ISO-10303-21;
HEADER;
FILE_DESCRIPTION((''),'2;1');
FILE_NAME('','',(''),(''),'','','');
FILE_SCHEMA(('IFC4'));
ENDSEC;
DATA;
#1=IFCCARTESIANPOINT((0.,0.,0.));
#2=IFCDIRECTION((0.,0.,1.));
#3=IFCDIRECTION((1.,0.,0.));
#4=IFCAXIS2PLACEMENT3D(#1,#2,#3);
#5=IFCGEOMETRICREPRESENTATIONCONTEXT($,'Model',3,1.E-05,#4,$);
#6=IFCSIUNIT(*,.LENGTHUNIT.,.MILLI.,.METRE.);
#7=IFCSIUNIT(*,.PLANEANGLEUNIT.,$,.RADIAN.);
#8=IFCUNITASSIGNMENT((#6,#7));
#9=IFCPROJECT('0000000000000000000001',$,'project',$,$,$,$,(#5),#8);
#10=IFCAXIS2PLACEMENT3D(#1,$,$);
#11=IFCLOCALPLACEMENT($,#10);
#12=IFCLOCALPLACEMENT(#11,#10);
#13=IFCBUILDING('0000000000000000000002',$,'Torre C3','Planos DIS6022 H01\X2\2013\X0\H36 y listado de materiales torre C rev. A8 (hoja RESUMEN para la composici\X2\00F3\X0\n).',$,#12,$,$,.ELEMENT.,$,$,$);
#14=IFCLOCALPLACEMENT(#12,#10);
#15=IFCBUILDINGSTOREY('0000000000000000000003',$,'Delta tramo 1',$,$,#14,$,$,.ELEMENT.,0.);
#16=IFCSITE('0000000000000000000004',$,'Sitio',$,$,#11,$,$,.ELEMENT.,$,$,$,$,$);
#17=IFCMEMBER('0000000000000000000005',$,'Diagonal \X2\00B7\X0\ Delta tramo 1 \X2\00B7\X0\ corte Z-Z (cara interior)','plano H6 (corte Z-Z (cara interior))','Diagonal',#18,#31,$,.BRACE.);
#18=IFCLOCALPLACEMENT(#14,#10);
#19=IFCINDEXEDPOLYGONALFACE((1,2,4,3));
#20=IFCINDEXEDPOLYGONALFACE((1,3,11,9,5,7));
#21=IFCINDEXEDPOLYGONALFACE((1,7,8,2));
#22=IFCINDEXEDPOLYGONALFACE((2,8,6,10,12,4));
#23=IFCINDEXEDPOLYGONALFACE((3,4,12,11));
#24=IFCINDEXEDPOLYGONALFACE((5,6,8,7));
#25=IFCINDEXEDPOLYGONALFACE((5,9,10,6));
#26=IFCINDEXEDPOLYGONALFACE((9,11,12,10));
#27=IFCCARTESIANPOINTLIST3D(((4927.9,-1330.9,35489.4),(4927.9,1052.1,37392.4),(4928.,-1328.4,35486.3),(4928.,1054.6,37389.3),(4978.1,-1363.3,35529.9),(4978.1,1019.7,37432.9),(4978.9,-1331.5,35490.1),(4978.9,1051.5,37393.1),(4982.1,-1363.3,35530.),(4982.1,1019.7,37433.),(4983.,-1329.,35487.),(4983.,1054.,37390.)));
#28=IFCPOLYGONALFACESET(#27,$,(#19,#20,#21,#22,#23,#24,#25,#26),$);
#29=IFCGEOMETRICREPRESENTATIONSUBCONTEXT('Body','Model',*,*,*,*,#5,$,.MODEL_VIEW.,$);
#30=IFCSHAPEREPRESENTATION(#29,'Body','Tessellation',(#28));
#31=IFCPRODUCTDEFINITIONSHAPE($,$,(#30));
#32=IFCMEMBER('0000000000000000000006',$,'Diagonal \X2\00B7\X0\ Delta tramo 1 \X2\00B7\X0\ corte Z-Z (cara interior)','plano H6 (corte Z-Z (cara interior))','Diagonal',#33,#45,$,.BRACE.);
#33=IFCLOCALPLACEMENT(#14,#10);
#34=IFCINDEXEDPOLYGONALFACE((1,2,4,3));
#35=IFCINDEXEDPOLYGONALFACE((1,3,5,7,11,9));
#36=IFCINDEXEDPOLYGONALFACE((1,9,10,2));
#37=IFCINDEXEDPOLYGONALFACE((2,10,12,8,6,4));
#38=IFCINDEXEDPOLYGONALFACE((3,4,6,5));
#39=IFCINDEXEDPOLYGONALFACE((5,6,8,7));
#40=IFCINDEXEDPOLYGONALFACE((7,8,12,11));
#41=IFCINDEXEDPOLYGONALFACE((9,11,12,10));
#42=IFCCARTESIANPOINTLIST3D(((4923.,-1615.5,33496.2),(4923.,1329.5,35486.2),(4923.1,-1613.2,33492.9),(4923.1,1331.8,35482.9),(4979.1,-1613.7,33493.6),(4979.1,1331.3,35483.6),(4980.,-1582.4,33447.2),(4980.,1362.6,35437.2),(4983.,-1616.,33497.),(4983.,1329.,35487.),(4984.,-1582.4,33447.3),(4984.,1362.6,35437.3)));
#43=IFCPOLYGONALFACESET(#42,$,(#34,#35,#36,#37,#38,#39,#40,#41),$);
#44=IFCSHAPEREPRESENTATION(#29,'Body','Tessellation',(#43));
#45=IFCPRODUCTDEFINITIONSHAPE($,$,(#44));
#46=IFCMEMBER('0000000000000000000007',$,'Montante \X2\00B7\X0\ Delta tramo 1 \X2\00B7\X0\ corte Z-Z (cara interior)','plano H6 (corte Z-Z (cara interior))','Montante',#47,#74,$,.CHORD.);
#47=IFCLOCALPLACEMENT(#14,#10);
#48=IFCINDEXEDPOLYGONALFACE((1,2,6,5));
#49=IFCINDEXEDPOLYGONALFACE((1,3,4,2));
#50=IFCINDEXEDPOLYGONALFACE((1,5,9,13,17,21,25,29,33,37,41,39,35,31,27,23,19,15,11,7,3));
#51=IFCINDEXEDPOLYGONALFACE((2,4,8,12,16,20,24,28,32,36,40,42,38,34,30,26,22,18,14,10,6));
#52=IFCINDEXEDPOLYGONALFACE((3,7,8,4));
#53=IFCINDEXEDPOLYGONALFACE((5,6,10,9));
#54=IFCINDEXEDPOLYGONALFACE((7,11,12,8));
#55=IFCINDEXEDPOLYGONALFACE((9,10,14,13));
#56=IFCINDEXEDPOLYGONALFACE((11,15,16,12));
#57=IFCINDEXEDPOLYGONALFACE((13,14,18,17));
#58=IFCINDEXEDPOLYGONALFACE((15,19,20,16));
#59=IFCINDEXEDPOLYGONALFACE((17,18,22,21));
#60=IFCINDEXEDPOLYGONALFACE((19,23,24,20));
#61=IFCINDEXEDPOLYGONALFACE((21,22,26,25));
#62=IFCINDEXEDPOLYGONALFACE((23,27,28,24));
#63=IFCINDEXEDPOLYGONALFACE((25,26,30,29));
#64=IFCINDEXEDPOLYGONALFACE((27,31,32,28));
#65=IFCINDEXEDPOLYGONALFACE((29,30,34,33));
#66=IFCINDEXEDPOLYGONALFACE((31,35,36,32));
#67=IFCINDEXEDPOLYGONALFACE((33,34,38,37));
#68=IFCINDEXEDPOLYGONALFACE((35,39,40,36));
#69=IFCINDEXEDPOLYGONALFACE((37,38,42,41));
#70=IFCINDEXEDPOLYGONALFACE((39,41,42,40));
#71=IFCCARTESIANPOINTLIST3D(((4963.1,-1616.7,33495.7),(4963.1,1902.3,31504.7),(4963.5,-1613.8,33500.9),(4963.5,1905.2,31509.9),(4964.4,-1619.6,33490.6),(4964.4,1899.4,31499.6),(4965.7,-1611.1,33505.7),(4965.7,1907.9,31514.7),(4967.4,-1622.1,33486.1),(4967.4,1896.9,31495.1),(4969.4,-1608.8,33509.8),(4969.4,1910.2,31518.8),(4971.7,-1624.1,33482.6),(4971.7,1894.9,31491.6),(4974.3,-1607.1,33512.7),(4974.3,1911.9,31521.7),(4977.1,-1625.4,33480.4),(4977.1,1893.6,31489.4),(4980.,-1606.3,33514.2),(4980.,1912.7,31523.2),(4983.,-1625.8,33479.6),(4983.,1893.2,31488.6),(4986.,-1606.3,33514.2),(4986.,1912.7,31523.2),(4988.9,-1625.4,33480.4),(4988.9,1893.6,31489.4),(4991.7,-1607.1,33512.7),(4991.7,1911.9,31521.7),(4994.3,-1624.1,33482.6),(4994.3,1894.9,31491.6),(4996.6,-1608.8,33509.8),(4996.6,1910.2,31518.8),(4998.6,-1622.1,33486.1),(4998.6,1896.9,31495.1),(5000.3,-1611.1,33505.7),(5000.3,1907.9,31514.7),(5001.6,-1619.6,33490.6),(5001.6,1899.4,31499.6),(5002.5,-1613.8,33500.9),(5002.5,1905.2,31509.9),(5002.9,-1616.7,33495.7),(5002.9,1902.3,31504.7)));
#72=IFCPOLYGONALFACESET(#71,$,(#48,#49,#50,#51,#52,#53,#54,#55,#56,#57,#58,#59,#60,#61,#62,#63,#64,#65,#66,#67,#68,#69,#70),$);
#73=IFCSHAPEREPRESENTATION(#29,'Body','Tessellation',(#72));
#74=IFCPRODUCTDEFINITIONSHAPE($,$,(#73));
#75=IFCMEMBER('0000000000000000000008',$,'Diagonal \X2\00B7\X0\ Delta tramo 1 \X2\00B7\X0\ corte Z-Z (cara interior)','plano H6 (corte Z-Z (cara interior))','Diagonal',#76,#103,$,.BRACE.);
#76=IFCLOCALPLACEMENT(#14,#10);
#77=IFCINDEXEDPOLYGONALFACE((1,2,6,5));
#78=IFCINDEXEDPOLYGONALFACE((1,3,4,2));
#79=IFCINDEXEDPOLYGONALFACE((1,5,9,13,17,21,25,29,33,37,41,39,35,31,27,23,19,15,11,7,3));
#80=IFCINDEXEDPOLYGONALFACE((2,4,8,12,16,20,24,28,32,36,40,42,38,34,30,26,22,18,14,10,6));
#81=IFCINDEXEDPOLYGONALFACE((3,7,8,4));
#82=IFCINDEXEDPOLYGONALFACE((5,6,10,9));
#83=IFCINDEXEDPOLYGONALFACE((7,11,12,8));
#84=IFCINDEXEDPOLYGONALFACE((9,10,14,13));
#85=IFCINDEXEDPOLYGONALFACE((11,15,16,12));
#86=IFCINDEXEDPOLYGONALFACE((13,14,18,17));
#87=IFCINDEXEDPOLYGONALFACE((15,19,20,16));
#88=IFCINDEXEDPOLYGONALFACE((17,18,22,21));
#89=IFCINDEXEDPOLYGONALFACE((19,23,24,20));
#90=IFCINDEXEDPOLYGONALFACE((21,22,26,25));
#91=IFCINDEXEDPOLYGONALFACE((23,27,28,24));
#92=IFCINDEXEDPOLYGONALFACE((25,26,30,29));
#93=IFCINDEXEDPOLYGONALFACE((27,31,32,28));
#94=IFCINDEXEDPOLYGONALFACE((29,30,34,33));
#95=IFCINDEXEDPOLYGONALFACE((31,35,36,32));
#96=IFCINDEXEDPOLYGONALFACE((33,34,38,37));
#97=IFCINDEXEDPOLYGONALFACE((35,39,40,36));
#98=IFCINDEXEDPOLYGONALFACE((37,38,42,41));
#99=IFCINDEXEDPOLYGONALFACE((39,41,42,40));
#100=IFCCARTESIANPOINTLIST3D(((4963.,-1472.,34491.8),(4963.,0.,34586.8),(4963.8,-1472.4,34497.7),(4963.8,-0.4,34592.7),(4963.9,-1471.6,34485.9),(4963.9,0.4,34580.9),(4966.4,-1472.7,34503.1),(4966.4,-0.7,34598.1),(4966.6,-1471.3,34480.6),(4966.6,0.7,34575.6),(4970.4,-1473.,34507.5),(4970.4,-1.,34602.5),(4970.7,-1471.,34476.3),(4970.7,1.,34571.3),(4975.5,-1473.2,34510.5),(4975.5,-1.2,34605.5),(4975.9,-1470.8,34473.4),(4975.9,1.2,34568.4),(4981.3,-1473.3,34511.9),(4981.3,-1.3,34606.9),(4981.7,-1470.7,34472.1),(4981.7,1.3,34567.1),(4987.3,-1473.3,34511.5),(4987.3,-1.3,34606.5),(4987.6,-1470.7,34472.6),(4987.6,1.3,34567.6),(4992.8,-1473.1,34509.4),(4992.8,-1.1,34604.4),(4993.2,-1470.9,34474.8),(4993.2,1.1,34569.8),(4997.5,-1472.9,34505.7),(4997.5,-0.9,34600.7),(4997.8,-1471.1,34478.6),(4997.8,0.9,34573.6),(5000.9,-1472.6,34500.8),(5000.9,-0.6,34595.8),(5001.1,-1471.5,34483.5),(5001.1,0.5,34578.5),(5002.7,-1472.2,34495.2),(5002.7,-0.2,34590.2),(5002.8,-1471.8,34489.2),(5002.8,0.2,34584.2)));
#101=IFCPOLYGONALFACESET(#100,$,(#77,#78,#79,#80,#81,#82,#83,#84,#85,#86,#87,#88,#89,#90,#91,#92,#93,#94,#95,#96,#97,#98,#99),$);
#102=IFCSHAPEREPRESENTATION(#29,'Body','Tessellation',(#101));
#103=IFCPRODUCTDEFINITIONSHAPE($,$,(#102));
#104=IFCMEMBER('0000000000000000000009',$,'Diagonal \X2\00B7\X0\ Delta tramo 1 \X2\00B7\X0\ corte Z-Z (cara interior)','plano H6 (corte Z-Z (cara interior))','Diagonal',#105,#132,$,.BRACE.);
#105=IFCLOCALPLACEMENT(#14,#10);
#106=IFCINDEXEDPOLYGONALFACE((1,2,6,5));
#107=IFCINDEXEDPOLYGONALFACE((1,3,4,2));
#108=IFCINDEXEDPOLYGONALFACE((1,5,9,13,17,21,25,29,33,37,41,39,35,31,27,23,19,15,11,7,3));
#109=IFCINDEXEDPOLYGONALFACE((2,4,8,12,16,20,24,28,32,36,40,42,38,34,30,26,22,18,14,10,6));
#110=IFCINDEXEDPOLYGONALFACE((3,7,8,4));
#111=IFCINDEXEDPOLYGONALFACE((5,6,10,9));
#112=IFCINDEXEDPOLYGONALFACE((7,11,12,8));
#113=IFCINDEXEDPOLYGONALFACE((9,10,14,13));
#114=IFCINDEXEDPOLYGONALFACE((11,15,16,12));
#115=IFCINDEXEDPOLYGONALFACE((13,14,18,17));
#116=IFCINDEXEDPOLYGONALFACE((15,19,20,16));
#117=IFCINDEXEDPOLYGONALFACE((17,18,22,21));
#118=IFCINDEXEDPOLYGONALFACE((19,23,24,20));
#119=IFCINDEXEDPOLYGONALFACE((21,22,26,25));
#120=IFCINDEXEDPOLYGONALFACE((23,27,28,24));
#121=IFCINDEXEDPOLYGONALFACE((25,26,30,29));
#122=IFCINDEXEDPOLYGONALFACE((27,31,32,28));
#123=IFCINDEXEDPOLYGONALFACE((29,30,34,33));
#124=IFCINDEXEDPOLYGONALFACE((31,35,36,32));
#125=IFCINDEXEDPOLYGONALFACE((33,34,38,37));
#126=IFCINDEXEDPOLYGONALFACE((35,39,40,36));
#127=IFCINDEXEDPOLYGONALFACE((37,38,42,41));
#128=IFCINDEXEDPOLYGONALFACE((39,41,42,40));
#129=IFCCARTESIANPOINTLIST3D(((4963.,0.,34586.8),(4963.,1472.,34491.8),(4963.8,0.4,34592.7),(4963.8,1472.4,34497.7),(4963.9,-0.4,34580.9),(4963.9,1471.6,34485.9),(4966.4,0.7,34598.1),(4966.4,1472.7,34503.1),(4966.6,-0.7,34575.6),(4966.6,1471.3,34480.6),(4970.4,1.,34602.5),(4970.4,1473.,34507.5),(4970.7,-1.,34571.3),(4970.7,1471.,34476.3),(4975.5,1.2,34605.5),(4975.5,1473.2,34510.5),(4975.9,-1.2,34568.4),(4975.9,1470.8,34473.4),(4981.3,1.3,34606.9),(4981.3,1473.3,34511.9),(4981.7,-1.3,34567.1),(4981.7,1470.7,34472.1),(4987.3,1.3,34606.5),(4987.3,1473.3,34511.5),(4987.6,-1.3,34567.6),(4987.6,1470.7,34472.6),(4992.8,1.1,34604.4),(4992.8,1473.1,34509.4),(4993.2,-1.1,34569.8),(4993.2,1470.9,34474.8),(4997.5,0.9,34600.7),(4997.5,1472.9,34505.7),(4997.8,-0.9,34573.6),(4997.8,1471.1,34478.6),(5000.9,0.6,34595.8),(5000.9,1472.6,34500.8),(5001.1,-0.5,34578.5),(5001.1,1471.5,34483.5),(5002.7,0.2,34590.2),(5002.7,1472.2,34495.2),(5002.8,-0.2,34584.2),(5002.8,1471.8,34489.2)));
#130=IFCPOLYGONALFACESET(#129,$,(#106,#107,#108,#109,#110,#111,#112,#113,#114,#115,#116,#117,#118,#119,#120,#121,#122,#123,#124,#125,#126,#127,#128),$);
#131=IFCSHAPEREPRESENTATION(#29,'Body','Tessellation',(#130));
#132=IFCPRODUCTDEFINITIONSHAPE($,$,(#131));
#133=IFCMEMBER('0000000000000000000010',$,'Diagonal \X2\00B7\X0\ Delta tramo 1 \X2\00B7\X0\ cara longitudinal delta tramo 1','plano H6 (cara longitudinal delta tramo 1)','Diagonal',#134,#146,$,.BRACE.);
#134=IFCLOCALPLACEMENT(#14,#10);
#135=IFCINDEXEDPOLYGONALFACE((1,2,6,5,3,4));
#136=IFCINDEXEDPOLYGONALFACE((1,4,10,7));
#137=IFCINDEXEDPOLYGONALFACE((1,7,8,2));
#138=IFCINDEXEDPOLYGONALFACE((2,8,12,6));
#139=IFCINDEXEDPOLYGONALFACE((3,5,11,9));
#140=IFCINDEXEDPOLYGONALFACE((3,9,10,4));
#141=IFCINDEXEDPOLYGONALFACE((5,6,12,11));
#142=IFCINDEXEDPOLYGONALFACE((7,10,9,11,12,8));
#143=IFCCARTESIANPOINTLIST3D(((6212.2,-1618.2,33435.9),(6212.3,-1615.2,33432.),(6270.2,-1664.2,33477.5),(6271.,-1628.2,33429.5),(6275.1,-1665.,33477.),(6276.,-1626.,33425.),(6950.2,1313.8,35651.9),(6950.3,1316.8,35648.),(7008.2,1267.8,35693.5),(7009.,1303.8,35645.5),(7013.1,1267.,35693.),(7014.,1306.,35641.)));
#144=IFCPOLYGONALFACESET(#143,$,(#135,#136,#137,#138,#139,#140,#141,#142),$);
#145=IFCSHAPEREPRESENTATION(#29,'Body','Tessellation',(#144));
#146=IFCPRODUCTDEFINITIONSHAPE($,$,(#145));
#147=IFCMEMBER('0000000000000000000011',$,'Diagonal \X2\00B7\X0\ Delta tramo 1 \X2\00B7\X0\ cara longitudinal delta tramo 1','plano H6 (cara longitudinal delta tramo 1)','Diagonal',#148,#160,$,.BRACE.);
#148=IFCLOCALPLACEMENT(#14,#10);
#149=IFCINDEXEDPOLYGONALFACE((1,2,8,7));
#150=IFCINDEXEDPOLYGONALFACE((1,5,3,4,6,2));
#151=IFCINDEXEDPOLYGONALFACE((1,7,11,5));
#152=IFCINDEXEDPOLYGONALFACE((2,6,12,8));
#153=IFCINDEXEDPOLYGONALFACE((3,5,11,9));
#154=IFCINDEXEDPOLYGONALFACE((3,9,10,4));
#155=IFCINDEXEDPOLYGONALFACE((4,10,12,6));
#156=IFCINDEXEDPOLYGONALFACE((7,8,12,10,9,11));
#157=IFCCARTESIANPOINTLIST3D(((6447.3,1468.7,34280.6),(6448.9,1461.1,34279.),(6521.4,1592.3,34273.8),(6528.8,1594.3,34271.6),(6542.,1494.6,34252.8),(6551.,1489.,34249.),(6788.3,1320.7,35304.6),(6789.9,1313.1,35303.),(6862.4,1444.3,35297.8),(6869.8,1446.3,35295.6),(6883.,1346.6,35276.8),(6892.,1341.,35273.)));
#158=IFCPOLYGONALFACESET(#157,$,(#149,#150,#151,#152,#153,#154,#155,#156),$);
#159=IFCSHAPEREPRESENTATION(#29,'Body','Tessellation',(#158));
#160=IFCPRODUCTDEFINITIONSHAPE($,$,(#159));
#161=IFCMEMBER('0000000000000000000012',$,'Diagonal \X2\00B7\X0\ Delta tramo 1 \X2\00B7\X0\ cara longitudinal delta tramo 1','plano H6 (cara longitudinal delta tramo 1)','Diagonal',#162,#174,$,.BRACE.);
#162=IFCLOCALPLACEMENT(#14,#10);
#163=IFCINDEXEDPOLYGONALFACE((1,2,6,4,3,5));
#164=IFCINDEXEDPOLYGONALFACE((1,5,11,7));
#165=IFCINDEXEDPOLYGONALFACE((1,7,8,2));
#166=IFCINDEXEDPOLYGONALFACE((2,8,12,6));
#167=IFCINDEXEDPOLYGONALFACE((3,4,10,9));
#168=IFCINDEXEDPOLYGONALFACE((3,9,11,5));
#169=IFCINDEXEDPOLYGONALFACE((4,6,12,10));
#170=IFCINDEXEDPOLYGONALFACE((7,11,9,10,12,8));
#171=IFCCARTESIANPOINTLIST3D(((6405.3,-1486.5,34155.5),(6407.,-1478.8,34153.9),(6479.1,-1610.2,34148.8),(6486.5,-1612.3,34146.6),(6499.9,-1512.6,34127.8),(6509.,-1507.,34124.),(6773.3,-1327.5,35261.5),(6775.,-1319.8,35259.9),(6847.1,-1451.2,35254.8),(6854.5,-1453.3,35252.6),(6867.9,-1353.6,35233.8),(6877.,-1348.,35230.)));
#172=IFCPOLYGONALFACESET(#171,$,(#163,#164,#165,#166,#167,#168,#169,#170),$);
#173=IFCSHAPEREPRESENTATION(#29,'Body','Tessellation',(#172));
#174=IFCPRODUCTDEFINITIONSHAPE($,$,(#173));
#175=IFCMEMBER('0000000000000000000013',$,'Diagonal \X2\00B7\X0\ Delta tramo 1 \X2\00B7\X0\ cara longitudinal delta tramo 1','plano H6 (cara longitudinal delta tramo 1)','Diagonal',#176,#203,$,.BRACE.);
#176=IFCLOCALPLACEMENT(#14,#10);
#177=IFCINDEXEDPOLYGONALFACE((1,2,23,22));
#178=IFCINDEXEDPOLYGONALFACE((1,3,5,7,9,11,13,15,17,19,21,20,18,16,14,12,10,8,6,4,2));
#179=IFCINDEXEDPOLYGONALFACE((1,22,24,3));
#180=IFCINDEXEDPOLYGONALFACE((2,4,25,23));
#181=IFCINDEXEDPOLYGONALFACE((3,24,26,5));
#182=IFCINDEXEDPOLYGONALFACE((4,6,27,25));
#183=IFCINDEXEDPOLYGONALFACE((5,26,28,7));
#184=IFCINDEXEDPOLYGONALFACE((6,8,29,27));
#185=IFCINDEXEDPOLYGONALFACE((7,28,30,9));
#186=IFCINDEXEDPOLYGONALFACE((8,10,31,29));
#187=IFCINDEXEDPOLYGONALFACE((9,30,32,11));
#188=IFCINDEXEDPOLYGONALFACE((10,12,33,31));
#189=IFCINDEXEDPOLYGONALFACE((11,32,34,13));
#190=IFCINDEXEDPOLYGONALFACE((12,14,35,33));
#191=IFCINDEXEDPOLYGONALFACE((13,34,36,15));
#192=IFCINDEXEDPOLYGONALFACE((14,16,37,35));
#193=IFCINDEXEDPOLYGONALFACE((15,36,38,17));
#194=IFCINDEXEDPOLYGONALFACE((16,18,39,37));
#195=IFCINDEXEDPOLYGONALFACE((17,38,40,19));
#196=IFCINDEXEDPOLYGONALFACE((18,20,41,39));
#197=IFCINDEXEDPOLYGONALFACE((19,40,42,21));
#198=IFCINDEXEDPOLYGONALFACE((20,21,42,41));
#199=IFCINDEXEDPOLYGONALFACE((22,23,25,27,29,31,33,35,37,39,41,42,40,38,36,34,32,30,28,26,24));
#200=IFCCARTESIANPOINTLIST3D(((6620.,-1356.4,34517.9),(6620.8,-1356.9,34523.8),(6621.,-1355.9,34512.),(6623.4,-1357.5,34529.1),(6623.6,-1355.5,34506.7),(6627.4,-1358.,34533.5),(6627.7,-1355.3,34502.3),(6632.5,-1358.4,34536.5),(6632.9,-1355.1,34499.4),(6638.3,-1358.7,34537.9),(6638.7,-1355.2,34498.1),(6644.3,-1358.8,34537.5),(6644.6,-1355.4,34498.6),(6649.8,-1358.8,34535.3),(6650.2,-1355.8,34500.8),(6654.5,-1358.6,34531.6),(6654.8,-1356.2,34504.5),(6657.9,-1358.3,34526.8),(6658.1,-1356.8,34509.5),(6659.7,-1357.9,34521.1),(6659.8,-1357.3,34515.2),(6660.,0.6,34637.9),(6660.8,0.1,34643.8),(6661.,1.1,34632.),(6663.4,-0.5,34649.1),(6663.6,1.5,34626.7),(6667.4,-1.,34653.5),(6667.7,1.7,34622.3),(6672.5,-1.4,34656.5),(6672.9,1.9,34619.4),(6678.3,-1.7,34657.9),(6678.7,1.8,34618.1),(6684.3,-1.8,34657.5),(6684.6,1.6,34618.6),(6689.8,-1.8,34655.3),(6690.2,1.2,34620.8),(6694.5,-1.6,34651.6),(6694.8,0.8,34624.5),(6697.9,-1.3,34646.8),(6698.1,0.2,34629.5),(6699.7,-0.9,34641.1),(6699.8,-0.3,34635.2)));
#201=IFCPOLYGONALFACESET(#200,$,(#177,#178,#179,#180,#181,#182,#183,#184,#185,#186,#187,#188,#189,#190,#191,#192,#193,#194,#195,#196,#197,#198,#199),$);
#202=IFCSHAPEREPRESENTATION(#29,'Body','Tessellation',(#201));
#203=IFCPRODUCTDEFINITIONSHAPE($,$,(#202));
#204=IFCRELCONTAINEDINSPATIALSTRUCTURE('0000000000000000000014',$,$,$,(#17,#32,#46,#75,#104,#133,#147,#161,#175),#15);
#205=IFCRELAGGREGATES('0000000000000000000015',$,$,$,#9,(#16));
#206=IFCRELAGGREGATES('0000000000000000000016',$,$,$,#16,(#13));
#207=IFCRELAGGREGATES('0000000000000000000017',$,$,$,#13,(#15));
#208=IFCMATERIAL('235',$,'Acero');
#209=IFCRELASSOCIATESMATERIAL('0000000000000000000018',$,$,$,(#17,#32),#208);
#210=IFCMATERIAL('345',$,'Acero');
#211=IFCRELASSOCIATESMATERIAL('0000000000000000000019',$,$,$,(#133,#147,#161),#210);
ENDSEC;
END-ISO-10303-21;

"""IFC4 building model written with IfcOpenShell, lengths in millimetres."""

from ifc_helpers import new_model, si_unit, frame, frame_2d, origin, origin_with_axes, place, context, subcontext, project, spatial, circle, l_section, extrude, material, element, save


model = new_model("IFC4")

# Units and contexts
model_context = context("Model", 3, precision=1e-05, world=origin_with_axes())
body_context = subcontext(model_context, "Body", "Model", "MODEL_VIEW")
ifc_project = project(units=[si_unit("LENGTHUNIT", "METRE", prefix="MILLI"), si_unit("PLANEANGLEUNIT", "RADIAN")], contexts=[model_context])

# Site, building, storey
site_placement = place(None, origin())
site = spatial("IfcSite", under=ifc_project, at=site_placement, Name="Sitio", CompositionType="ELEMENT")
building_placement = place(site_placement, origin())
building = spatial("IfcBuilding", under=site, at=building_placement, Name="Torre C3", Description="Planos DIS6022 H01–H36 y listado de materiales torre C rev. A8 (hoja RESUMEN para la composición).", CompositionType="ELEMENT")
storey_placement = place(building_placement, origin())
storey = spatial("IfcBuildingStorey", under=building, at=storey_placement, Name="Delta tramo 1", CompositionType="ELEMENT", Elevation=0.0)

# Members
ifc_material_1 = material(Name="345", Category="Acero")
ifc_material_2 = material(Name="235", Category="Acero")
member_1_placement = place(storey_placement, frame((4983.0, -1329.0, 35487.0), z_axis=(0.0, 0.781412, 0.624015), x_axis=(-0.999852, 0.010743, -0.013453)))
element("IfcMember", 1, at=member_1_placement, inside=storey, material=ifc_material_2, Name="Diagonal · Delta tramo 1 · corte Z-Z (cara interior)", Description="plano H6 (corte Z-Z (cara interior))", ObjectType="Diagonal", PredefinedType="BRACE", context=body_context, shape_type="SweptSolid", body=[
    extrude(l_section(Depth=55.0, Width=55.0, Thickness=4.0, at=frame_2d((27.5, 27.5))), None, (0.0, 0.0, 1.0), 3049.6),
])
member_2_placement = place(storey_placement, frame((4983.0, 1329.0, 35487.0), z_axis=(0.0, -0.828571, -0.559884), x_axis=(-0.99987, 0.009026, -0.013358)))
element("IfcMember", 2, at=member_2_placement, inside=storey, material=ifc_material_2, Name="Diagonal · Delta tramo 1 · corte Z-Z (cara interior)", Description="plano H6 (corte Z-Z (cara interior))", ObjectType="Diagonal", PredefinedType="BRACE", context=body_context, shape_type="SweptSolid", body=[
    extrude(l_section(Depth=60.0, Width=60.0, Thickness=4.0, at=frame_2d((30.0, 30.0))), None, (0.0, 0.0, 1.0), 3554.3),
])
member_3_placement = place(storey_placement, frame((4983.0, -1616.0, 33497.0), z_axis=(0.0, 0.870351, -0.492432), x_axis=(0.0, -0.492432, -0.870351)))
element("IfcMember", 3, at=member_3_placement, inside=storey, Name="Montante · Delta tramo 1 · corte Z-Z (cara interior)", Description="plano H6 (corte Z-Z (cara interior))", ObjectType="Montante", PredefinedType="CHORD", context=body_context, shape_type="SweptSolid", body=[
    extrude(circle(Radius=20.0), None, (0.0, 0.0, 1.0), 4043.2),
])
for number, where, z_axis, x_axis, name in (
    (4, (4983.0, -1472.0, 34492.0), (0.0, 0.997924, 0.064404), (-0.999955, 0.000613, -0.009492), "Diagonal · Delta tramo 1 · corte Z-Z (cara interior)"),
    (5, (4983.0, 1472.0, 34492.0), (0.0, -0.997924, 0.064404), (-0.999955, -0.000613, -0.009492), "Diagonal · Delta tramo 1 · corte Z-Z (cara interior)"),
):
    element("IfcMember", number, at=place(storey_placement, frame(where, z_axis=z_axis, x_axis=x_axis)), inside=storey, Name=name, Description="plano H6 (corte Z-Z (cara interior))", ObjectType="Diagonal", PredefinedType="BRACE", context=body_context, shape_type="SweptSolid", body=[
        extrude(circle(Radius=20.0), None, (0.0, 0.0, 1.0), 1475.1),
    ])
member_4_placement = place(storey_placement, frame((6276.0, -1626.0, 33425.0), z_axis=(0.196874, 0.782161, 0.591156), x_axis=(-0.980322, 0.165937, 0.106927)))
element("IfcMember", 6, at=member_4_placement, inside=storey, material=ifc_material_1, Name="Diagonal · Delta tramo 1 · cara longitudinal delta tramo 1", Description="plano H6 (cara longitudinal delta tramo 1)", ObjectType="Diagonal", PredefinedType="BRACE", context=body_context, shape_type="SweptSolid", body=[
    extrude(l_section(Depth=65.0, Width=65.0, Thickness=5.0, at=frame_2d((32.5, 32.5))), None, (0.0, 0.0, 1.0), 3748.6),
])
member_5_placement = place(storey_placement, frame((6892.0, 1341.0, 35273.0), z_axis=(-0.31302, 0.135856, -0.939979), x_axis=(-0.928102, -0.253844, 0.272377)))
element("IfcMember", 7, at=member_5_placement, inside=storey, material=ifc_material_1, Name="Diagonal · Delta tramo 1 · cara longitudinal delta tramo 1", Description="plano H6 (cara longitudinal delta tramo 1)", ObjectType="Diagonal", PredefinedType="BRACE", context=body_context, shape_type="SweptSolid", body=[
    extrude(l_section(Depth=110.0, Width=110.0, Thickness=8.0, at=frame_2d((55.0, 55.0))), None, (0.0, 0.0, 1.0), 1089.4),
])
member_6_placement = place(storey_placement, frame((6509.0, -1507.0, 34124.0), z_axis=(0.312816, 0.135157, 0.940148), x_axis=(-0.927617, 0.25621, 0.271813)))
element("IfcMember", 8, at=member_6_placement, inside=storey, material=ifc_material_1, Name="Diagonal · Delta tramo 1 · cara longitudinal delta tramo 1", Description="plano H6 (cara longitudinal delta tramo 1)", ObjectType="Diagonal", PredefinedType="BRACE", context=body_context, shape_type="SweptSolid", body=[
    extrude(l_section(Depth=110.0, Width=110.0, Thickness=8.0, at=frame_2d((55.0, 55.0))), None, (0.0, 0.0, 1.0), 1176.4),
])
for number, where, z_axis, x_axis, name in (
    (9, (6680.0, 0.0, 34638.0), (-0.02935, -0.995684, -0.088049), (-0.999529, 0.030023, -0.006331), "Diagonal · Delta tramo 1 · cara longitudinal delta tramo 1"),
):
    element("IfcMember", number, at=place(storey_placement, frame(where, z_axis=z_axis, x_axis=x_axis)), inside=storey, Name=name, Description="plano H6 (cara longitudinal delta tramo 1)", ObjectType="Diagonal", PredefinedType="BRACE", context=body_context, shape_type="SweptSolid", body=[
        extrude(circle(Radius=20.0), None, (0.0, 0.0, 1.0), 1362.9),
    ])

save(model, "model.ifc")
